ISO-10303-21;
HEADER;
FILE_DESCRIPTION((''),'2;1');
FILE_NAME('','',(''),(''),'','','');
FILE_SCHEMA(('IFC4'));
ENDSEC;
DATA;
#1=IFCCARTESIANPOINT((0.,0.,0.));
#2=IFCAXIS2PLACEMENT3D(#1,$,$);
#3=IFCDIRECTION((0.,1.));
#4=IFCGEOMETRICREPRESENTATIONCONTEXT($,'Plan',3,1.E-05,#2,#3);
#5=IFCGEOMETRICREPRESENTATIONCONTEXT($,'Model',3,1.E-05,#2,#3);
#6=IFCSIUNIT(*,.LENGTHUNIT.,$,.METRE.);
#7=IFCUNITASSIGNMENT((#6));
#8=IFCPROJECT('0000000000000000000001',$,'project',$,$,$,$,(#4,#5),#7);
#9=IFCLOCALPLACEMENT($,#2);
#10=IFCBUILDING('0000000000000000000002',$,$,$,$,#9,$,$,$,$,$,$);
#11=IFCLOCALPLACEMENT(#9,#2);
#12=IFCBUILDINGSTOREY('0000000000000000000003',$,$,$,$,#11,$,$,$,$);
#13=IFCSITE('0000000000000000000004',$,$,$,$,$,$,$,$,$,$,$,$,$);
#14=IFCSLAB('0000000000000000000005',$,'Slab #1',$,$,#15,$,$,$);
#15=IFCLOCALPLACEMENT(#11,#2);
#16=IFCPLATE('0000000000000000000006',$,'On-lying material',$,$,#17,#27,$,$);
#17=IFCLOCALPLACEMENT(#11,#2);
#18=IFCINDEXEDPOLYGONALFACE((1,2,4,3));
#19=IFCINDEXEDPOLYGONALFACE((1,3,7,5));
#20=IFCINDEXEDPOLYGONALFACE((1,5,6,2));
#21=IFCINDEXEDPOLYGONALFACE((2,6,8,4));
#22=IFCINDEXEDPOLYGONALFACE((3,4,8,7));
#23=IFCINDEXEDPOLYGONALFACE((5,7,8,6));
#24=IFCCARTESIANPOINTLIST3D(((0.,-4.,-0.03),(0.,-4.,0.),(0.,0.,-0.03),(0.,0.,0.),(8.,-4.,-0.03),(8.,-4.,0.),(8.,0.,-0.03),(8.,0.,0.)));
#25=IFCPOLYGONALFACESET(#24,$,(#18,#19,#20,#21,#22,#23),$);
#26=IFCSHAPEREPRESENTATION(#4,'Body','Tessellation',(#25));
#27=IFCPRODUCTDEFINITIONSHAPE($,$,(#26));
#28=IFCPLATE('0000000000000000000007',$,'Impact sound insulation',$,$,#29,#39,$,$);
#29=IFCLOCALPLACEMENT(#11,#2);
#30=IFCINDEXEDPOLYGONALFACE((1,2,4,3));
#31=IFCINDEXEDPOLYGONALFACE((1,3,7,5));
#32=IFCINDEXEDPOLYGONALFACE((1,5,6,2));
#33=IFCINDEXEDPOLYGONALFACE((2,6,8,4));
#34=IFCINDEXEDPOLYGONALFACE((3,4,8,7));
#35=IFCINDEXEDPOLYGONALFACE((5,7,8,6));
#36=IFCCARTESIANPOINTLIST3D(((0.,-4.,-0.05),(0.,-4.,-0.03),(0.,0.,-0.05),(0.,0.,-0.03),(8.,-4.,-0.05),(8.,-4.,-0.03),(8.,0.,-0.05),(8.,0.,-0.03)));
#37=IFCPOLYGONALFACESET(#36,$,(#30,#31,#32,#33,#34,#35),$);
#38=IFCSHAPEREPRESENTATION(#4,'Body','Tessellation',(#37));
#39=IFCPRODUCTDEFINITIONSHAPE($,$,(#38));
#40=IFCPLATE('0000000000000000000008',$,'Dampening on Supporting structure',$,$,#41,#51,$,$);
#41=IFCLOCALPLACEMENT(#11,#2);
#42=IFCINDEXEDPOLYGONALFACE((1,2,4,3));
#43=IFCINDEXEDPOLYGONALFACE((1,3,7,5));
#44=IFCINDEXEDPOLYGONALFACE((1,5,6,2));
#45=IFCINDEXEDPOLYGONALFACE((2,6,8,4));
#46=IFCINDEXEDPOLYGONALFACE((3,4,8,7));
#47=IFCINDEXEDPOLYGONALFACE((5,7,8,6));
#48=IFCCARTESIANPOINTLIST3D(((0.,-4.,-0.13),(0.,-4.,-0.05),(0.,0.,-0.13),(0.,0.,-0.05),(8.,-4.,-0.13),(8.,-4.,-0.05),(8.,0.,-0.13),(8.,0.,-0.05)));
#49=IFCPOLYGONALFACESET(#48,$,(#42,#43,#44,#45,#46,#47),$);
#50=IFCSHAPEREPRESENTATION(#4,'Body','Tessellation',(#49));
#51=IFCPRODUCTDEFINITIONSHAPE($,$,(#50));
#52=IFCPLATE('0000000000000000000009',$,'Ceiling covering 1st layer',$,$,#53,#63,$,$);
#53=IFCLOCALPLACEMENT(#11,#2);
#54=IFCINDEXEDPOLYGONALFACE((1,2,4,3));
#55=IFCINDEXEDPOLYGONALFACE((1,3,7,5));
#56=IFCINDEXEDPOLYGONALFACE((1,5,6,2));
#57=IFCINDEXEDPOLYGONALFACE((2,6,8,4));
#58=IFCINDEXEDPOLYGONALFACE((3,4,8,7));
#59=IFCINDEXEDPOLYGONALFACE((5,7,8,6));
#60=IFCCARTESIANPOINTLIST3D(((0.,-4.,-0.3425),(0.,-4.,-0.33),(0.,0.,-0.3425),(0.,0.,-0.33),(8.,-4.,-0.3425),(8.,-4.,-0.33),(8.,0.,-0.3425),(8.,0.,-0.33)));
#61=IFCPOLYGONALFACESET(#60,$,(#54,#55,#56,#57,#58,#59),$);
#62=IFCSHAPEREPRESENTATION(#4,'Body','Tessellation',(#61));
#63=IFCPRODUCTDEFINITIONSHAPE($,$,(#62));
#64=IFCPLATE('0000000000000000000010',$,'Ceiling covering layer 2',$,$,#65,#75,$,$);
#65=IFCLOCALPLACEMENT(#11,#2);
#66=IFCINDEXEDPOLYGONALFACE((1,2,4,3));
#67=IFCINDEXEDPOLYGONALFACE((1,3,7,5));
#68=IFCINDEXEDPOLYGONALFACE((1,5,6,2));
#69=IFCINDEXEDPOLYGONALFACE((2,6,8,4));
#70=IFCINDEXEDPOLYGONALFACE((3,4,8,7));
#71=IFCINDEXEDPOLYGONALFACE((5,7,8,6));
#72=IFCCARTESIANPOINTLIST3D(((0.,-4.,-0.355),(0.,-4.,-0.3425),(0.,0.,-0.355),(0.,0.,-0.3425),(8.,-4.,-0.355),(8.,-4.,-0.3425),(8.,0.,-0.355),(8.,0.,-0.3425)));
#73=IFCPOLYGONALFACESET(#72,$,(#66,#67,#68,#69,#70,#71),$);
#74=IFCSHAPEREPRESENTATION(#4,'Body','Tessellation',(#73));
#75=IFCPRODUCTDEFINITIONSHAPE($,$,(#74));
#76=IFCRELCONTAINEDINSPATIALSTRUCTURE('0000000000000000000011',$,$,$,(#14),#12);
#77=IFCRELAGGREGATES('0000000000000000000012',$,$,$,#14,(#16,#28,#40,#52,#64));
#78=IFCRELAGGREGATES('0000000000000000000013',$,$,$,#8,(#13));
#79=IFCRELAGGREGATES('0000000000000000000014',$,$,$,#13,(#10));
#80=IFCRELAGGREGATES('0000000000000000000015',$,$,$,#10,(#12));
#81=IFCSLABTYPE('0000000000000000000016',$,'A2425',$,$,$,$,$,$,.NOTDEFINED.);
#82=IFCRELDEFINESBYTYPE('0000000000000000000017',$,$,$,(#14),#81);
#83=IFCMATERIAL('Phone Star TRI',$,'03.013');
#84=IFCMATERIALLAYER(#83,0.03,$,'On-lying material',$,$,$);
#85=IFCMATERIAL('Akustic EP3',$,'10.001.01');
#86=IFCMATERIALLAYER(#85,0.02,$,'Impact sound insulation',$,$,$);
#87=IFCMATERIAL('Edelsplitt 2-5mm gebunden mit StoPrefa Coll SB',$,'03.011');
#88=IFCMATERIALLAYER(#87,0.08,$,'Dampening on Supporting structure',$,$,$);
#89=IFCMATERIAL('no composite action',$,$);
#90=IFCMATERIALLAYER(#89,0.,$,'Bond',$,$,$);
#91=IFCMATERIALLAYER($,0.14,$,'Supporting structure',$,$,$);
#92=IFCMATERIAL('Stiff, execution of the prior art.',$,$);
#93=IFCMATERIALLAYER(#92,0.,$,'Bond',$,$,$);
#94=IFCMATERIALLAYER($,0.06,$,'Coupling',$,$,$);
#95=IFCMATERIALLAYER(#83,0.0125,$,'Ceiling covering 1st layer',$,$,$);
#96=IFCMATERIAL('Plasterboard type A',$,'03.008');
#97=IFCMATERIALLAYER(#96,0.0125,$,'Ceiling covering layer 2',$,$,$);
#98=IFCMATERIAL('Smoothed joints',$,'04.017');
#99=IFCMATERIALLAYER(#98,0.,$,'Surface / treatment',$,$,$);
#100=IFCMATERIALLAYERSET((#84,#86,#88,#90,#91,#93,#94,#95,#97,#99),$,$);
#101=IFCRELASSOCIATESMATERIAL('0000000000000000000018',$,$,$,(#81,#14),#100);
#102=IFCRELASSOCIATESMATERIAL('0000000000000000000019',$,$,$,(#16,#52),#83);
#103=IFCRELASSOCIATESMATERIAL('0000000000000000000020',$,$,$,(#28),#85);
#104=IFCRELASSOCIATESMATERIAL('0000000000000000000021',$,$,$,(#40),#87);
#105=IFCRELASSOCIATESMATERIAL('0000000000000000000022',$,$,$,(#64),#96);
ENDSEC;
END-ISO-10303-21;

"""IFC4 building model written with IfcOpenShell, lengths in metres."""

from ifc_helpers import new_model, si_unit, direction, frame, frame_2d, origin, origin_with_axes, place, context, project, spatial, rectangle, extrude, material, layer, layer_set, type_object, element, aggregate, save


model = new_model("IFC4")

# Units and contexts
plan_context = context("Plan", 3, precision=1e-05, world=origin(), true_north=direction((0.0, 1.0)))
model_context = context("Model", 3, precision=1e-05, world=origin(), true_north=direction((0.0, 1.0)))
ifc_project = project(units=[si_unit("LENGTHUNIT", "METRE")], contexts=[plan_context, model_context])

# Site, building, storey
site = spatial("IfcSite", under=ifc_project)
building_placement = place(None, origin())
building = spatial("IfcBuilding", under=site, at=building_placement)
storey_placement = place(building_placement, origin())
storey = spatial("IfcBuildingStorey", under=building, at=storey_placement)

# Slab, plates
ifc_material_1 = material(Name="Phone Star TRI", Category="03.013")
ifc_layer_1 = layer(ifc_material_1, 0.03, Name="On-lying material")
ifc_material_2 = material(Name="Akustic EP3", Category="10.001.01")
ifc_layer_2 = layer(ifc_material_2, 0.02, Name="Impact sound insulation")
ifc_material_3 = material(Name="Edelsplitt 2-5mm gebunden mit StoPrefa Coll SB", Category="03.011")
ifc_layer_3 = layer(ifc_material_3, 0.08, Name="Dampening on Supporting structure")
ifc_material_4 = material(Name="no composite action")
ifc_layer_4 = layer(ifc_material_4, 0.0, Name="Bond")
ifc_layer_5 = layer(None, 0.14, Name="Supporting structure")
ifc_material_5 = material(Name="Stiff, execution of the prior art.")
ifc_layer_6 = layer(ifc_material_5, 0.0, Name="Bond")
ifc_layer_7 = layer(None, 0.06, Name="Coupling")
ifc_layer_8 = layer(ifc_material_1, 0.0125, Name="Ceiling covering 1st layer")
ifc_material_6 = material(Name="Plasterboard type A", Category="03.008")
ifc_layer_9 = layer(ifc_material_6, 0.0125, Name="Ceiling covering layer 2")
ifc_material_7 = material(Name="Smoothed joints", Category="04.017")
ifc_layer_10 = layer(ifc_material_7, 0.0, Name="Surface / treatment")
ifc_layer_set = layer_set([ifc_layer_1, ifc_layer_2, ifc_layer_3, ifc_layer_4, ifc_layer_5, ifc_layer_6, ifc_layer_7, ifc_layer_8, ifc_layer_9, ifc_layer_10])
slab_type = type_object("IfcSlabType", Name="A2425", PredefinedType="NOTDEFINED", material=ifc_layer_set)
slab_placement = place(None, frame((0.0, 0.0, 0.0), z_axis=(0.0, 0.0, -1.0), x_axis=(1.0, 0.0, 0.0)))
slab = element("IfcSlab", 1, at=slab_placement, inside=storey, type_object=slab_type, material=ifc_layer_set, Name="Slab #1")
plate_1_placement = place(slab_placement, origin())
plate_1 = element("IfcPlate", 2, at=plate_1_placement, material=ifc_material_1, Name="On-lying material", context=plan_context, shape_type="SweptSolid", body=[
    extrude(rectangle(XDim=8.0, YDim=4.0, at=frame_2d((4.0, 2.0), x_axis=(1.0, 0.0))), origin_with_axes(), (0.0, 0.0, 1.0), 0.03),
])
plate_2_placement = place(slab_placement, origin())
plate_2 = element("IfcPlate", 3, at=plate_2_placement, material=ifc_material_2, Name="Impact sound insulation", context=plan_context, shape_type="SweptSolid", body=[
    extrude(rectangle(XDim=8.0, YDim=4.0, at=frame_2d((4.0, 2.0), x_axis=(1.0, 0.0))), frame((0.0, 0.0, 0.03), z_axis=(0.0, 0.0, 1.0), x_axis=(1.0, 0.0, 0.0)), (0.0, 0.0, 1.0), 0.02),
])
plate_3_placement = place(slab_placement, origin())
plate_3 = element("IfcPlate", 4, at=plate_3_placement, material=ifc_material_3, Name="Dampening on Supporting structure", context=plan_context, shape_type="SweptSolid", body=[
    extrude(rectangle(XDim=8.0, YDim=4.0, at=frame_2d((4.0, 2.0), x_axis=(1.0, 0.0))), frame((0.0, 0.0, 0.05), z_axis=(0.0, 0.0, 1.0), x_axis=(1.0, 0.0, 0.0)), (0.0, 0.0, 1.0), 0.08),
])
plate_4_placement = place(slab_placement, origin())
plate_4 = element("IfcPlate", 5, at=plate_4_placement, material=ifc_material_1, Name="Ceiling covering 1st layer", context=plan_context, shape_type="SweptSolid", body=[
    extrude(rectangle(XDim=8.0, YDim=4.0, at=frame_2d((4.0, 2.0), x_axis=(1.0, 0.0))), frame((0.0, 0.0, 0.33), z_axis=(0.0, 0.0, 1.0), x_axis=(1.0, 0.0, 0.0)), (0.0, 0.0, 1.0), 0.0125),
])
plate_5_placement = place(slab_placement, origin())
plate_5 = element("IfcPlate", 6, at=plate_5_placement, material=ifc_material_6, Name="Ceiling covering layer 2", context=plan_context, shape_type="SweptSolid", body=[
    extrude(rectangle(XDim=8.0, YDim=4.0, at=frame_2d((4.0, 2.0), x_axis=(1.0, 0.0))), frame((0.0, 0.0, 0.3425), z_axis=(0.0, 0.0, 1.0), x_axis=(1.0, 0.0, 0.0)), (0.0, 0.0, 1.0), 0.0125),
])
aggregate(slab, [plate_1, plate_2, plate_3, plate_4, plate_5])

save(model, "model.ifc")
